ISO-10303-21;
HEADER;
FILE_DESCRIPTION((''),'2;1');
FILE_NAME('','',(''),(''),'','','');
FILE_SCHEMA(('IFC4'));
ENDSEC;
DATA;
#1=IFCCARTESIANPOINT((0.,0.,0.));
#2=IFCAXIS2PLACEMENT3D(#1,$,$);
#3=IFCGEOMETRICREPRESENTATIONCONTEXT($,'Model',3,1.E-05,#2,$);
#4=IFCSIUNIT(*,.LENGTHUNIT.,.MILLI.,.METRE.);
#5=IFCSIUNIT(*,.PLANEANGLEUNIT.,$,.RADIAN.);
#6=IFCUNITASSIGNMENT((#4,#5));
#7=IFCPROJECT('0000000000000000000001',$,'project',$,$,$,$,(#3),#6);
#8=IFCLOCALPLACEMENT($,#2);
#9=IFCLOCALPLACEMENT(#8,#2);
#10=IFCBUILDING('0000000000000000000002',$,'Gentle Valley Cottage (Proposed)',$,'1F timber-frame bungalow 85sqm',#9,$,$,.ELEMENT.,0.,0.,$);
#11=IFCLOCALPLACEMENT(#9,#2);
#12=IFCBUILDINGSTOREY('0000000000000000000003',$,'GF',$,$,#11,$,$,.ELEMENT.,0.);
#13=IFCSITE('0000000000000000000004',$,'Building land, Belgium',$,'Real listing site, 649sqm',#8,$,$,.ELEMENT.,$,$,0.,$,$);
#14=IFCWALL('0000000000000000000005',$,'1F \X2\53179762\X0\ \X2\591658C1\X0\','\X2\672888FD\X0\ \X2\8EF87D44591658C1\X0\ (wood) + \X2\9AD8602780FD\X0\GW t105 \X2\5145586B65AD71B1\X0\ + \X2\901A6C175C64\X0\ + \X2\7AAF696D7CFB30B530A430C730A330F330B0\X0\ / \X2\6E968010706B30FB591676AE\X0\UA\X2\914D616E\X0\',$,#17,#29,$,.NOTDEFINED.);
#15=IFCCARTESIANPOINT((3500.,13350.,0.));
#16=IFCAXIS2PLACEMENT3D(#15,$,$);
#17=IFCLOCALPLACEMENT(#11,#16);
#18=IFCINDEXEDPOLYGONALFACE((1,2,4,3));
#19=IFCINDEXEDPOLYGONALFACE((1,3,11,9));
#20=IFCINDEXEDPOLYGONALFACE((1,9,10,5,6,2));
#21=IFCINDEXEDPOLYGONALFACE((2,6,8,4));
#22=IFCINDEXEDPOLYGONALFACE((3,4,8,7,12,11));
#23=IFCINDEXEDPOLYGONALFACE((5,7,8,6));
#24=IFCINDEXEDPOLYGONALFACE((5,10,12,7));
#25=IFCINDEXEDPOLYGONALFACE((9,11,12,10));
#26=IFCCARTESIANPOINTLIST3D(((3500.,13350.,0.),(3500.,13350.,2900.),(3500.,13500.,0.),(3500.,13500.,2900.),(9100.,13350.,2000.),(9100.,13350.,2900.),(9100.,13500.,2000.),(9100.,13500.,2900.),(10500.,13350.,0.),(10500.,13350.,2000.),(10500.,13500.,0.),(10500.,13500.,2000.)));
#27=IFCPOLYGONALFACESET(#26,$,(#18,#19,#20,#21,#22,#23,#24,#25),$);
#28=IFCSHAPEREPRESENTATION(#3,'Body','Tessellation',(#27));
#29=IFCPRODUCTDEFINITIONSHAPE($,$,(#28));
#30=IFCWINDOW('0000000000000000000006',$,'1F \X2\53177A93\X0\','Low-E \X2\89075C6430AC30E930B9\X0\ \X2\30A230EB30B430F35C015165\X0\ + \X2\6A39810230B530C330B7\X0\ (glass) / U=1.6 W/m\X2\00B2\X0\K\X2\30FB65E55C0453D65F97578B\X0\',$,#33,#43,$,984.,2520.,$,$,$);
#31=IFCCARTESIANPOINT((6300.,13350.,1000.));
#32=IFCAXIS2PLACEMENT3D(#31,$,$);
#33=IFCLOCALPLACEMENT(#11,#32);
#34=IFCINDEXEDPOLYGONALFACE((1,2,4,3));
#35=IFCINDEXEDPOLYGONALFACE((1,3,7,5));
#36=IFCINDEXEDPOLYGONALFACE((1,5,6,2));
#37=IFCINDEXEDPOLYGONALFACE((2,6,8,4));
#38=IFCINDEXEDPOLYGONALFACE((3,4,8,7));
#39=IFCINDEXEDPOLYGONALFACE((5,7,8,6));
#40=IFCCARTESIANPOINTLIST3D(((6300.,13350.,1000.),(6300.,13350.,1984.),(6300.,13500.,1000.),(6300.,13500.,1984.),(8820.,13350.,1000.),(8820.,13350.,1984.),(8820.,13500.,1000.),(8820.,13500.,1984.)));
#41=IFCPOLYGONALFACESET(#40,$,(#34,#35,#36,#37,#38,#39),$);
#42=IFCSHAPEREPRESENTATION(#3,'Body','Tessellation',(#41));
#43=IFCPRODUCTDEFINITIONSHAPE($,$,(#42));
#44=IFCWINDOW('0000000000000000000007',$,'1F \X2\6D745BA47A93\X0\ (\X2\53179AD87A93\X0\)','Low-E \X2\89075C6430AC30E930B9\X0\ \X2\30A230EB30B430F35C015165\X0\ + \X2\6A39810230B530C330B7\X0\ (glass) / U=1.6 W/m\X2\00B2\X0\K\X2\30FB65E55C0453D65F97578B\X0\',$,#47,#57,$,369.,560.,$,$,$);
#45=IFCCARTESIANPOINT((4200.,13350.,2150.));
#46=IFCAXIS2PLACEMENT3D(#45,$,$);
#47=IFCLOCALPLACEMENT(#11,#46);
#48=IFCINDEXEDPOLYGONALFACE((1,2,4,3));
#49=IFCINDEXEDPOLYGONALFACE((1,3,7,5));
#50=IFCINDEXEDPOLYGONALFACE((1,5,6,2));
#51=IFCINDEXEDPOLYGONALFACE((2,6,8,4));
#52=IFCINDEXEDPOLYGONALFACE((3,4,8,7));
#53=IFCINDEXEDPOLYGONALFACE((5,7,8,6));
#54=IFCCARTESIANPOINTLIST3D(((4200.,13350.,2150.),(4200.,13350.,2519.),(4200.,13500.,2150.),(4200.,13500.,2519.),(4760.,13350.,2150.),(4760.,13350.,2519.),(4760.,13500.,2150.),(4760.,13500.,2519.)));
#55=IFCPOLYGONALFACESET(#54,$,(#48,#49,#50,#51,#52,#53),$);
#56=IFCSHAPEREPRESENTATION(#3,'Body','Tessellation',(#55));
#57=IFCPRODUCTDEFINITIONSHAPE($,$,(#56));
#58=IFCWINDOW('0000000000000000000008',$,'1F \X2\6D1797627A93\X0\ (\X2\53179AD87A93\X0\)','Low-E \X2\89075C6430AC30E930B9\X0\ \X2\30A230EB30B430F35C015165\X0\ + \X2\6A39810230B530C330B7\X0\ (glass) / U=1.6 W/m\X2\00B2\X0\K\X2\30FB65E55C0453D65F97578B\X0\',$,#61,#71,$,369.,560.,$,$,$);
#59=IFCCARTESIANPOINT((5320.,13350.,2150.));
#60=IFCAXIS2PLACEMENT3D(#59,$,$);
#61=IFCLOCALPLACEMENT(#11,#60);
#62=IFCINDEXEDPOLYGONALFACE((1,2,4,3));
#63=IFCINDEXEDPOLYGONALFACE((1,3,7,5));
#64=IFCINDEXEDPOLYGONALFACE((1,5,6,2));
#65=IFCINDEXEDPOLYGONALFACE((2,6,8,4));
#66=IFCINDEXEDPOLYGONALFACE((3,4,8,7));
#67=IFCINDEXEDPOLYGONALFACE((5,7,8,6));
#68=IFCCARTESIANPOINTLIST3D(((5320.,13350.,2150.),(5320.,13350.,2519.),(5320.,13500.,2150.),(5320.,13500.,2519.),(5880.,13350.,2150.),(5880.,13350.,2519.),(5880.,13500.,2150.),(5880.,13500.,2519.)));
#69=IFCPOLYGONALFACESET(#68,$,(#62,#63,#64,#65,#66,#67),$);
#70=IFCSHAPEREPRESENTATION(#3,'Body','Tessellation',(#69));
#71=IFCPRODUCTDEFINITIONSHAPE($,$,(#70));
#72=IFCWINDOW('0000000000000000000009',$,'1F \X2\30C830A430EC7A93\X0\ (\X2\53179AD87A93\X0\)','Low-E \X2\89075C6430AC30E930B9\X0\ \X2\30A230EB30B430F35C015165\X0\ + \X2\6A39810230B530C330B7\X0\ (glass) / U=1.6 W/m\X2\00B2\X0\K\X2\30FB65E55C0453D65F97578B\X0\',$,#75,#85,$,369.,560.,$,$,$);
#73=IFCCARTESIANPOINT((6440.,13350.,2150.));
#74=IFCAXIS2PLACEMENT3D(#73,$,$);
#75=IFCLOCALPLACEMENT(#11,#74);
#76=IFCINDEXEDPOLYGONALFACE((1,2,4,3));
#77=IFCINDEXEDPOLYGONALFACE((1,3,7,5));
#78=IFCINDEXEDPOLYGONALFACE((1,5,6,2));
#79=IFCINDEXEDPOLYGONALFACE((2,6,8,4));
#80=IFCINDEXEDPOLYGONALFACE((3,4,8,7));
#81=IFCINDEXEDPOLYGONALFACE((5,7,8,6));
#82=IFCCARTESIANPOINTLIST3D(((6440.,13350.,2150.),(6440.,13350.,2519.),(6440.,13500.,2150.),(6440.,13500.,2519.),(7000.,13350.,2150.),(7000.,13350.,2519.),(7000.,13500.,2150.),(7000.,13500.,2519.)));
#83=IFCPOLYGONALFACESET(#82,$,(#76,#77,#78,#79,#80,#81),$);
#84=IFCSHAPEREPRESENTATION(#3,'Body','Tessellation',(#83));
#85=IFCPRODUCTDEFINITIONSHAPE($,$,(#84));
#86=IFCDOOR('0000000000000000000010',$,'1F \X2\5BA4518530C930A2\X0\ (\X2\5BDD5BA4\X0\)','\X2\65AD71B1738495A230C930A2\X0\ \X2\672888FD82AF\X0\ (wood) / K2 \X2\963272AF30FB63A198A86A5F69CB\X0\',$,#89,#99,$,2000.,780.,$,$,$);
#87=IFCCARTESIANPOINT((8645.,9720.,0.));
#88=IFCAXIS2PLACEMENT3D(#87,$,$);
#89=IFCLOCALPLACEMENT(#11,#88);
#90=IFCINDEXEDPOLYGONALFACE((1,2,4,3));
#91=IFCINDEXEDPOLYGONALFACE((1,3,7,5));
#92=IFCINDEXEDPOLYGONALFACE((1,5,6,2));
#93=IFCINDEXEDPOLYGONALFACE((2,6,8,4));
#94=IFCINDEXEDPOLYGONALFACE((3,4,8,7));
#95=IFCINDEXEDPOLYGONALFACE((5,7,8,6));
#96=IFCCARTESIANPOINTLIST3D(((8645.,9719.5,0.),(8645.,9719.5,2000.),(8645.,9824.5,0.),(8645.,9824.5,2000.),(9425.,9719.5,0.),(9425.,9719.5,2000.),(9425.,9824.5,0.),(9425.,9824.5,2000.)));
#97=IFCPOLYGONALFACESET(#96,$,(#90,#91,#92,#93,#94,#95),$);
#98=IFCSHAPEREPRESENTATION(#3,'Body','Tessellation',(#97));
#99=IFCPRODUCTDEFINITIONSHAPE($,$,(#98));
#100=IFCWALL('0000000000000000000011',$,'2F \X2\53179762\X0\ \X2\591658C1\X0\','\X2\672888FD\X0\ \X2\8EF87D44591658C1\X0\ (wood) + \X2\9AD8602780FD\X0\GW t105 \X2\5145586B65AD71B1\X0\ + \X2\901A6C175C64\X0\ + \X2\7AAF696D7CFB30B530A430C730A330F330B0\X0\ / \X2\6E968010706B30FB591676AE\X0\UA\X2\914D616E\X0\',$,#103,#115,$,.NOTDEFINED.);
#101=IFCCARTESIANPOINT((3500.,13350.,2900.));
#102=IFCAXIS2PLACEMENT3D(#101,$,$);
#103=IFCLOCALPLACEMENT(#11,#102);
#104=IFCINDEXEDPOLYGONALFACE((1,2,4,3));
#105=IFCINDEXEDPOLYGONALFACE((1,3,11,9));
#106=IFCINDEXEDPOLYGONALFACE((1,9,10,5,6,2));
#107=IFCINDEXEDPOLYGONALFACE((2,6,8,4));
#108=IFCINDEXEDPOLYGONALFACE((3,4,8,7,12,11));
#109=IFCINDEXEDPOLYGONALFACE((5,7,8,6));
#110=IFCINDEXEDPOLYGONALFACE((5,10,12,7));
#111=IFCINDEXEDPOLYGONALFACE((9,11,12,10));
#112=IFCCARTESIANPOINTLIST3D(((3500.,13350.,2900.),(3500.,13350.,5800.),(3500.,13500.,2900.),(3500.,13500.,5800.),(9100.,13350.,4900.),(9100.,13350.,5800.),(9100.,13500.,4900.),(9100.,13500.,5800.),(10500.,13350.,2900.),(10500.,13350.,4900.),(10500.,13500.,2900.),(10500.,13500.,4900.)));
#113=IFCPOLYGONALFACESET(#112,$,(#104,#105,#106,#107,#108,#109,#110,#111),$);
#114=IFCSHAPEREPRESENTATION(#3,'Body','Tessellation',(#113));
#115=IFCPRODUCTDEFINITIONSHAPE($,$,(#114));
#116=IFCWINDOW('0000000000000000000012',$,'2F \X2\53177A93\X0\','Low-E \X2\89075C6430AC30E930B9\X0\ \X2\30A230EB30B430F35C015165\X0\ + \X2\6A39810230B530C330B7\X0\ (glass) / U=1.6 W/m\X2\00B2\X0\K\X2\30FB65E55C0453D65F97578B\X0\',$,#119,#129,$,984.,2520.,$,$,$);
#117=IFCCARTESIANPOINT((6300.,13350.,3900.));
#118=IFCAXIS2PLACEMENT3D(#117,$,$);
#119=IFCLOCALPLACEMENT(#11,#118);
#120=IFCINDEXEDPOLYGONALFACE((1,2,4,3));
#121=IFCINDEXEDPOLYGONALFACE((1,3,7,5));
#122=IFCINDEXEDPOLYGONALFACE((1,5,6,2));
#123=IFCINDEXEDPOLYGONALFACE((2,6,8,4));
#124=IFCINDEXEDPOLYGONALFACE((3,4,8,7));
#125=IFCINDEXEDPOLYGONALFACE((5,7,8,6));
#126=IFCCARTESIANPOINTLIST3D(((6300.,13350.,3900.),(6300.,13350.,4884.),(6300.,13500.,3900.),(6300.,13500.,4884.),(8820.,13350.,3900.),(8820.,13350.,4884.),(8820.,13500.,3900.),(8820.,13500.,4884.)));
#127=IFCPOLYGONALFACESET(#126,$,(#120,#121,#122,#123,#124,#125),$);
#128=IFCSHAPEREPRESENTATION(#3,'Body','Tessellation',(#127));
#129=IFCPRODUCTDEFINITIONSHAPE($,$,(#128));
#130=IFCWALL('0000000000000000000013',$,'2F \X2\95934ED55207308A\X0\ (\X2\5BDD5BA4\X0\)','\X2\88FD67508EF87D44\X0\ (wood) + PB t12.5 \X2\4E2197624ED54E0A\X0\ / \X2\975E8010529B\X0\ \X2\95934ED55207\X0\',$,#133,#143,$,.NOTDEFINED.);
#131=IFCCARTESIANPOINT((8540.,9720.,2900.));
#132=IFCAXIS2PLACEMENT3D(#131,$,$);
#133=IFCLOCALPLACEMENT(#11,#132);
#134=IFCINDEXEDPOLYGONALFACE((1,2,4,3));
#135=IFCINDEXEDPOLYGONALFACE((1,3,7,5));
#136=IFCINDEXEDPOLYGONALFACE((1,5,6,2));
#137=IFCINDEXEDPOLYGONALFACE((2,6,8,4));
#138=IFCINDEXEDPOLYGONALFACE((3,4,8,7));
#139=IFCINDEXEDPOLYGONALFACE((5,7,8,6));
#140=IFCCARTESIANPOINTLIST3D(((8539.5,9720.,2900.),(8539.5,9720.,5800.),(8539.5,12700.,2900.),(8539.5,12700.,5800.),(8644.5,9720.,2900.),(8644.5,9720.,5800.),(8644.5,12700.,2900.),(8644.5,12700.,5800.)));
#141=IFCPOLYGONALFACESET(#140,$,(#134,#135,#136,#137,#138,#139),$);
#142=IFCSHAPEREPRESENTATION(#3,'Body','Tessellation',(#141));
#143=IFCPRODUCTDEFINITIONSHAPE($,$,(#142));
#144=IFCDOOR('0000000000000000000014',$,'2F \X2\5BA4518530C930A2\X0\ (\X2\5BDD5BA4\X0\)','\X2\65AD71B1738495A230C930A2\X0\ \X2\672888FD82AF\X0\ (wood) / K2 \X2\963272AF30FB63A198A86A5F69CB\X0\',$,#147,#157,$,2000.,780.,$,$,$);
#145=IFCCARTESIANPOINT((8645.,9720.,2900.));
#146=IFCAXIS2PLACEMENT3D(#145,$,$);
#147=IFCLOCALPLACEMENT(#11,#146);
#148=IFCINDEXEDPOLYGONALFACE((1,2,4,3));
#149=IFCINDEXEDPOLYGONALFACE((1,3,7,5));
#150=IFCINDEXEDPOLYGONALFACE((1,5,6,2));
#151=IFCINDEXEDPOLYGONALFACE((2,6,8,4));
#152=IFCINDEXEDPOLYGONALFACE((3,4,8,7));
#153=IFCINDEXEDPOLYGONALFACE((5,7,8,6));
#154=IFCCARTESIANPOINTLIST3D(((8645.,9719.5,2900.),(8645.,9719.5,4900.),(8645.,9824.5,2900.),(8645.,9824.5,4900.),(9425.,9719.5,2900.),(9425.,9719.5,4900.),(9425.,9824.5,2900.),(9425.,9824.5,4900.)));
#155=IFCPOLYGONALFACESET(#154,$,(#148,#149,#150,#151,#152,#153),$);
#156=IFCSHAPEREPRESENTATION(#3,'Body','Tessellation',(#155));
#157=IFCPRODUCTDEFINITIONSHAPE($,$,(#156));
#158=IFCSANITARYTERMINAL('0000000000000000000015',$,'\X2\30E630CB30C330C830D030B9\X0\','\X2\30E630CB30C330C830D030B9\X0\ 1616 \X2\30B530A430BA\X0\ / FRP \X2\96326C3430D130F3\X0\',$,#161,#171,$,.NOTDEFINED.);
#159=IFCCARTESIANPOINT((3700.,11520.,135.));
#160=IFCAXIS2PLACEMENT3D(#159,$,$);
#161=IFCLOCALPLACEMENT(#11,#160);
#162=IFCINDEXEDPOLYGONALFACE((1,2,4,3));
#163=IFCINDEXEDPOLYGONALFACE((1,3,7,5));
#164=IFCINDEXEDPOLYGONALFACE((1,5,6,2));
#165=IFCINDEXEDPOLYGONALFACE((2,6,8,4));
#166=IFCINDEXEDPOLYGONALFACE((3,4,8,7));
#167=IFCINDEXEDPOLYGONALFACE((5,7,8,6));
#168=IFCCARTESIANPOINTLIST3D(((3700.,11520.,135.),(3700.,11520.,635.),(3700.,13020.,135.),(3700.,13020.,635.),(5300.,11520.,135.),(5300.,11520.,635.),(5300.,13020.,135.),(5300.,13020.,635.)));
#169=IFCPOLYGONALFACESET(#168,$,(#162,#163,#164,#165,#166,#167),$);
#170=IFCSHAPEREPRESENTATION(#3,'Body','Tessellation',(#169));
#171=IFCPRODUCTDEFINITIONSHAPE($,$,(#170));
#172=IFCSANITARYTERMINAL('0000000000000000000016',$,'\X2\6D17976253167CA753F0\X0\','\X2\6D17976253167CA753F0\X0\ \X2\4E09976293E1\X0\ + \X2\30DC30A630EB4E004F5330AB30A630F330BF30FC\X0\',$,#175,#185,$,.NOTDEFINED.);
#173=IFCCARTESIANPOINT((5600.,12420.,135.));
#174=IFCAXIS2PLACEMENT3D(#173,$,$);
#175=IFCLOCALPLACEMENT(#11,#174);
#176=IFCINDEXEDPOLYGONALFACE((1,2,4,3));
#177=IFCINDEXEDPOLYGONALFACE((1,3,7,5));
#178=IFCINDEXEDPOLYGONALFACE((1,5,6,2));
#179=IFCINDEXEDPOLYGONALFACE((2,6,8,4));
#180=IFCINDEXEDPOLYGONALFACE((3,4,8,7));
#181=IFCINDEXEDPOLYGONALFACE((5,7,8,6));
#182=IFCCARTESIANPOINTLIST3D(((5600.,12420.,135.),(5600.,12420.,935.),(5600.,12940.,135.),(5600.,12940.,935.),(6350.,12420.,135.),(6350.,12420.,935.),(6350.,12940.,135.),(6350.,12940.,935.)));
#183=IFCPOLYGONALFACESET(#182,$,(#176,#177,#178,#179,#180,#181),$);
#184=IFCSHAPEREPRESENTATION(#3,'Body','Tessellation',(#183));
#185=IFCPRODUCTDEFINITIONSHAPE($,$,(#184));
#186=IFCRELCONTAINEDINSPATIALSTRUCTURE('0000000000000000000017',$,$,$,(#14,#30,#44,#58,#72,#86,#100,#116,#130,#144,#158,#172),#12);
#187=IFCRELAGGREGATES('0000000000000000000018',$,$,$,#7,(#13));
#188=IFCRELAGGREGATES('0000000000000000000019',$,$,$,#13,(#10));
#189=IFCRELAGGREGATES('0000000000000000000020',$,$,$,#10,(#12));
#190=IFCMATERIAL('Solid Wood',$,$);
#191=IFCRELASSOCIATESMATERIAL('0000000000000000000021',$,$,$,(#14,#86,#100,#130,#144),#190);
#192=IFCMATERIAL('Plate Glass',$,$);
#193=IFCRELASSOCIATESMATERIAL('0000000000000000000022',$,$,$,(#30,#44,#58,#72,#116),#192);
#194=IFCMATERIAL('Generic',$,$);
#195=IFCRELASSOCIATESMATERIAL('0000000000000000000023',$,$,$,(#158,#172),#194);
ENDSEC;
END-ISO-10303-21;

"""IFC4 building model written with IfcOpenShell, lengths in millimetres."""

from ifc_helpers import new_model, si_unit, frame, frame_2d, origin, place, context, project, spatial, rectangle, extrude, material, element, fill, save


model = new_model("IFC4")

# Units and contexts
model_context = context("Model", 3, precision=1e-05, world=origin())
ifc_project = project(units=[si_unit("LENGTHUNIT", "METRE", prefix="MILLI"), si_unit("PLANEANGLEUNIT", "RADIAN")], contexts=[model_context])

# Site, building, storey
site_placement = place(None, origin())
site = spatial("IfcSite", under=ifc_project, at=site_placement, Name="Building land, Belgium", ObjectType="Real listing site, 649sqm", CompositionType="ELEMENT", RefElevation=0.0)
building_placement = place(site_placement, origin())
building = spatial("IfcBuilding", under=site, at=building_placement, Name="Gentle Valley Cottage (Proposed)", ObjectType="1F timber-frame bungalow 85sqm", CompositionType="ELEMENT", ElevationOfRefHeight=0.0, ElevationOfTerrain=0.0)
storey_placement = place(building_placement, origin())
storey = spatial("IfcBuildingStorey", under=building, at=storey_placement, Name="GF", CompositionType="ELEMENT", Elevation=0.0)

# Wall, openings, windows
ifc_material_1 = material(Name="Solid Wood")
wall_1_placement = place(storey_placement, frame((3500.0, 13350.0, 0.0)))
wall_1 = element("IfcWall", 1, at=wall_1_placement, inside=storey, material=ifc_material_1, Name="1F 北面 外壁", Description="木製 軸組外壁 (wood) + 高性能GW t105 充填断熱 + 通気層 + 窯業系サイディング / 準耐火・外皮UA配慮", PredefinedType="NOTDEFINED", context=model_context, shape_type="SweptSolid", body=[
    extrude(rectangle(XDim=7000.0, YDim=150.0, at=frame_2d((3500.0, 75.0))), frame((3500.0, 13350.0, 0.0)), (0.0, 0.0, 1.0), 2900.0),
])
opening_1_placement = place(storey_placement, frame((6300.0, 13350.0, 1000.0)))
opening_1 = element("IfcOpeningElement", 2, at=opening_1_placement, cuts=wall_1, PredefinedType="NOTDEFINED", context=model_context, shape_type="SweptSolid", body=[
    extrude(rectangle(XDim=2520.0, YDim=150.0, at=frame_2d((1260.0, 75.0))), frame((6300.0, 13350.0, 1000.0)), (0.0, 0.0, 1.0), 984.0),
])
opening_2_placement = place(storey_placement, frame((4200.0, 13350.0, 2150.0)))
opening_2 = element("IfcOpeningElement", 3, at=opening_2_placement, cuts=wall_1, PredefinedType="NOTDEFINED", context=model_context, shape_type="SweptSolid", body=[
    extrude(rectangle(XDim=560.0, YDim=150.0, at=frame_2d((280.0, 75.0))), frame((4200.0, 13350.0, 2150.0)), (0.0, 0.0, 1.0), 369.0),
])
opening_3_placement = place(storey_placement, frame((5320.0, 13350.0, 2150.0)))
opening_3 = element("IfcOpeningElement", 4, at=opening_3_placement, cuts=wall_1, PredefinedType="NOTDEFINED", context=model_context, shape_type="SweptSolid", body=[
    extrude(rectangle(XDim=560.0, YDim=150.0, at=frame_2d((280.0, 75.0))), frame((5320.0, 13350.0, 2150.0)), (0.0, 0.0, 1.0), 369.0),
])
opening_4_placement = place(storey_placement, frame((6440.0, 13350.0, 2150.0)))
opening_4 = element("IfcOpeningElement", 5, at=opening_4_placement, cuts=wall_1, PredefinedType="NOTDEFINED", context=model_context, shape_type="SweptSolid", body=[
    extrude(rectangle(XDim=560.0, YDim=150.0, at=frame_2d((280.0, 75.0))), frame((6440.0, 13350.0, 2150.0)), (0.0, 0.0, 1.0), 369.0),
])
ifc_material_2 = material(Name="Plate Glass")
window_1_placement = place(storey_placement, frame((6300.0, 13350.0, 1000.0)))
window_1 = element("IfcWindow", 6, at=window_1_placement, inside=storey, material=ifc_material_2, Name="1F 北窓", Description="Low-E 複層ガラス アルゴン封入 + 樹脂サッシ (glass) / U=1.6 W/m²K・日射取得型", OverallHeight=984.0, OverallWidth=2520.0, context=model_context, shape_type="SweptSolid", body=[
    extrude(rectangle(XDim=2520.0, YDim=150.0, at=frame_2d((1260.0, 75.0))), frame((6300.0, 13350.0, 1000.0)), (0.0, 0.0, 1.0), 984.0),
])
fill(opening_1, window_1)
window_2_placement = place(storey_placement, frame((4200.0, 13350.0, 2150.0)))
window_2 = element("IfcWindow", 7, at=window_2_placement, inside=storey, material=ifc_material_2, Name="1F 浴室窓 (北高窓)", Description="Low-E 複層ガラス アルゴン封入 + 樹脂サッシ (glass) / U=1.6 W/m²K・日射取得型", OverallHeight=369.0, OverallWidth=560.0, context=model_context, shape_type="SweptSolid", body=[
    extrude(rectangle(XDim=560.0, YDim=150.0, at=frame_2d((280.0, 75.0))), frame((4200.0, 13350.0, 2150.0)), (0.0, 0.0, 1.0), 369.0),
])
fill(opening_2, window_2)
window_3_placement = place(storey_placement, frame((5320.0, 13350.0, 2150.0)))
window_3 = element("IfcWindow", 8, at=window_3_placement, inside=storey, material=ifc_material_2, Name="1F 洗面窓 (北高窓)", Description="Low-E 複層ガラス アルゴン封入 + 樹脂サッシ (glass) / U=1.6 W/m²K・日射取得型", OverallHeight=369.0, OverallWidth=560.0, context=model_context, shape_type="SweptSolid", body=[
    extrude(rectangle(XDim=560.0, YDim=150.0, at=frame_2d((280.0, 75.0))), frame((5320.0, 13350.0, 2150.0)), (0.0, 0.0, 1.0), 369.0),
])
fill(opening_3, window_3)
window_4_placement = place(storey_placement, frame((6440.0, 13350.0, 2150.0)))
window_4 = element("IfcWindow", 9, at=window_4_placement, inside=storey, material=ifc_material_2, Name="1F トイレ窓 (北高窓)", Description="Low-E 複層ガラス アルゴン封入 + 樹脂サッシ (glass) / U=1.6 W/m²K・日射取得型", OverallHeight=369.0, OverallWidth=560.0, context=model_context, shape_type="SweptSolid", body=[
    extrude(rectangle(XDim=560.0, YDim=150.0, at=frame_2d((280.0, 75.0))), frame((6440.0, 13350.0, 2150.0)), (0.0, 0.0, 1.0), 369.0),
])
fill(opening_4, window_4)

# Door
door_1_placement = place(storey_placement, frame((8645.0, 9720.0, 0.0)))
element("IfcDoor", 10, at=door_1_placement, inside=storey, material=ifc_material_1, Name="1F 室内ドア (寝室)", Description="断熱玄関ドア 木製芯 (wood) / K2 防犯・採風機構", OverallHeight=2000.0, OverallWidth=780.0, context=model_context, shape_type="SweptSolid", body=[
    extrude(rectangle(XDim=780.0, YDim=105.0, at=frame_2d((390.0, 52.0))), frame((8645.0, 9720.0, 0.0)), (0.0, 0.0, 1.0), 2000.0),
])

# Wall, opening, window
wall_2_placement = place(storey_placement, frame((3500.0, 13350.0, 2900.0)))
wall_2 = element("IfcWall", 11, at=wall_2_placement, inside=storey, material=ifc_material_1, Name="2F 北面 外壁", Description="木製 軸組外壁 (wood) + 高性能GW t105 充填断熱 + 通気層 + 窯業系サイディング / 準耐火・外皮UA配慮", PredefinedType="NOTDEFINED", context=model_context, shape_type="SweptSolid", body=[
    extrude(rectangle(XDim=7000.0, YDim=150.0, at=frame_2d((3500.0, 75.0))), frame((3500.0, 13350.0, 2900.0)), (0.0, 0.0, 1.0), 2900.0),
])
opening_5_placement = place(storey_placement, frame((6300.0, 13350.0, 3900.0)))
opening_5 = element("IfcOpeningElement", 12, at=opening_5_placement, cuts=wall_2, PredefinedType="NOTDEFINED", context=model_context, shape_type="SweptSolid", body=[
    extrude(rectangle(XDim=2520.0, YDim=150.0, at=frame_2d((1260.0, 75.0))), frame((6300.0, 13350.0, 3900.0)), (0.0, 0.0, 1.0), 984.0),
])
window_5_placement = place(storey_placement, frame((6300.0, 13350.0, 3900.0)))
window_5 = element("IfcWindow", 13, at=window_5_placement, inside=storey, material=ifc_material_2, Name="2F 北窓", Description="Low-E 複層ガラス アルゴン封入 + 樹脂サッシ (glass) / U=1.6 W/m²K・日射取得型", OverallHeight=984.0, OverallWidth=2520.0, context=model_context, shape_type="SweptSolid", body=[
    extrude(rectangle(XDim=2520.0, YDim=150.0, at=frame_2d((1260.0, 75.0))), frame((6300.0, 13350.0, 3900.0)), (0.0, 0.0, 1.0), 984.0),
])
fill(opening_5, window_5)

# Wall
wall_3_placement = place(storey_placement, frame((8540.0, 9720.0, 2900.0)))
element("IfcWall", 14, at=wall_3_placement, inside=storey, material=ifc_material_1, Name="2F 間仕切り (寝室)", Description="製材軸組 (wood) + PB t12.5 両面仕上 / 非耐力 間仕切", PredefinedType="NOTDEFINED", context=model_context, shape_type="SweptSolid", body=[
    extrude(rectangle(XDim=105.0, YDim=2980.0, at=frame_2d((52.0, 1490.0))), frame((8540.0, 9720.0, 2900.0)), (0.0, 0.0, 1.0), 2900.0),
])

# Door
door_2_placement = place(storey_placement, frame((8645.0, 9720.0, 2900.0)))
element("IfcDoor", 15, at=door_2_placement, inside=storey, material=ifc_material_1, Name="2F 室内ドア (寝室)", Description="断熱玄関ドア 木製芯 (wood) / K2 防犯・採風機構", OverallHeight=2000.0, OverallWidth=780.0, context=model_context, shape_type="SweptSolid", body=[
    extrude(rectangle(XDim=780.0, YDim=105.0, at=frame_2d((390.0, 52.0))), frame((8645.0, 9720.0, 2900.0)), (0.0, 0.0, 1.0), 2000.0),
])

# Sanitary terminals
ifc_material_3 = material(Name="Generic")
sanitary_terminal_1_placement = place(storey_placement, frame((3700.0, 11520.0, 135.0)))
element("IfcSanitaryTerminal", 16, at=sanitary_terminal_1_placement, inside=storey, material=ifc_material_3, Name="ユニットバス", Description="ユニットバス 1616 サイズ / FRP 防水パン", PredefinedType="NOTDEFINED", context=model_context, shape_type="SweptSolid", body=[
    extrude(rectangle(XDim=1600.0, YDim=1500.0, at=frame_2d((800.0, 750.0))), frame((3700.0, 11520.0, 135.0)), (0.0, 0.0, 1.0), 500.0),
])
sanitary_terminal_2_placement = place(storey_placement, frame((5600.0, 12420.0, 135.0)))
element("IfcSanitaryTerminal", 17, at=sanitary_terminal_2_placement, inside=storey, material=ifc_material_3, Name="洗面化粧台", Description="洗面化粧台 三面鏡 + ボウル一体カウンター", PredefinedType="NOTDEFINED", context=model_context, shape_type="SweptSolid", body=[
    extrude(rectangle(XDim=750.0, YDim=520.0, at=frame_2d((375.0, 260.0))), frame((5600.0, 12420.0, 135.0)), (0.0, 0.0, 1.0), 800.0),
])

save(model, "model.ifc")
